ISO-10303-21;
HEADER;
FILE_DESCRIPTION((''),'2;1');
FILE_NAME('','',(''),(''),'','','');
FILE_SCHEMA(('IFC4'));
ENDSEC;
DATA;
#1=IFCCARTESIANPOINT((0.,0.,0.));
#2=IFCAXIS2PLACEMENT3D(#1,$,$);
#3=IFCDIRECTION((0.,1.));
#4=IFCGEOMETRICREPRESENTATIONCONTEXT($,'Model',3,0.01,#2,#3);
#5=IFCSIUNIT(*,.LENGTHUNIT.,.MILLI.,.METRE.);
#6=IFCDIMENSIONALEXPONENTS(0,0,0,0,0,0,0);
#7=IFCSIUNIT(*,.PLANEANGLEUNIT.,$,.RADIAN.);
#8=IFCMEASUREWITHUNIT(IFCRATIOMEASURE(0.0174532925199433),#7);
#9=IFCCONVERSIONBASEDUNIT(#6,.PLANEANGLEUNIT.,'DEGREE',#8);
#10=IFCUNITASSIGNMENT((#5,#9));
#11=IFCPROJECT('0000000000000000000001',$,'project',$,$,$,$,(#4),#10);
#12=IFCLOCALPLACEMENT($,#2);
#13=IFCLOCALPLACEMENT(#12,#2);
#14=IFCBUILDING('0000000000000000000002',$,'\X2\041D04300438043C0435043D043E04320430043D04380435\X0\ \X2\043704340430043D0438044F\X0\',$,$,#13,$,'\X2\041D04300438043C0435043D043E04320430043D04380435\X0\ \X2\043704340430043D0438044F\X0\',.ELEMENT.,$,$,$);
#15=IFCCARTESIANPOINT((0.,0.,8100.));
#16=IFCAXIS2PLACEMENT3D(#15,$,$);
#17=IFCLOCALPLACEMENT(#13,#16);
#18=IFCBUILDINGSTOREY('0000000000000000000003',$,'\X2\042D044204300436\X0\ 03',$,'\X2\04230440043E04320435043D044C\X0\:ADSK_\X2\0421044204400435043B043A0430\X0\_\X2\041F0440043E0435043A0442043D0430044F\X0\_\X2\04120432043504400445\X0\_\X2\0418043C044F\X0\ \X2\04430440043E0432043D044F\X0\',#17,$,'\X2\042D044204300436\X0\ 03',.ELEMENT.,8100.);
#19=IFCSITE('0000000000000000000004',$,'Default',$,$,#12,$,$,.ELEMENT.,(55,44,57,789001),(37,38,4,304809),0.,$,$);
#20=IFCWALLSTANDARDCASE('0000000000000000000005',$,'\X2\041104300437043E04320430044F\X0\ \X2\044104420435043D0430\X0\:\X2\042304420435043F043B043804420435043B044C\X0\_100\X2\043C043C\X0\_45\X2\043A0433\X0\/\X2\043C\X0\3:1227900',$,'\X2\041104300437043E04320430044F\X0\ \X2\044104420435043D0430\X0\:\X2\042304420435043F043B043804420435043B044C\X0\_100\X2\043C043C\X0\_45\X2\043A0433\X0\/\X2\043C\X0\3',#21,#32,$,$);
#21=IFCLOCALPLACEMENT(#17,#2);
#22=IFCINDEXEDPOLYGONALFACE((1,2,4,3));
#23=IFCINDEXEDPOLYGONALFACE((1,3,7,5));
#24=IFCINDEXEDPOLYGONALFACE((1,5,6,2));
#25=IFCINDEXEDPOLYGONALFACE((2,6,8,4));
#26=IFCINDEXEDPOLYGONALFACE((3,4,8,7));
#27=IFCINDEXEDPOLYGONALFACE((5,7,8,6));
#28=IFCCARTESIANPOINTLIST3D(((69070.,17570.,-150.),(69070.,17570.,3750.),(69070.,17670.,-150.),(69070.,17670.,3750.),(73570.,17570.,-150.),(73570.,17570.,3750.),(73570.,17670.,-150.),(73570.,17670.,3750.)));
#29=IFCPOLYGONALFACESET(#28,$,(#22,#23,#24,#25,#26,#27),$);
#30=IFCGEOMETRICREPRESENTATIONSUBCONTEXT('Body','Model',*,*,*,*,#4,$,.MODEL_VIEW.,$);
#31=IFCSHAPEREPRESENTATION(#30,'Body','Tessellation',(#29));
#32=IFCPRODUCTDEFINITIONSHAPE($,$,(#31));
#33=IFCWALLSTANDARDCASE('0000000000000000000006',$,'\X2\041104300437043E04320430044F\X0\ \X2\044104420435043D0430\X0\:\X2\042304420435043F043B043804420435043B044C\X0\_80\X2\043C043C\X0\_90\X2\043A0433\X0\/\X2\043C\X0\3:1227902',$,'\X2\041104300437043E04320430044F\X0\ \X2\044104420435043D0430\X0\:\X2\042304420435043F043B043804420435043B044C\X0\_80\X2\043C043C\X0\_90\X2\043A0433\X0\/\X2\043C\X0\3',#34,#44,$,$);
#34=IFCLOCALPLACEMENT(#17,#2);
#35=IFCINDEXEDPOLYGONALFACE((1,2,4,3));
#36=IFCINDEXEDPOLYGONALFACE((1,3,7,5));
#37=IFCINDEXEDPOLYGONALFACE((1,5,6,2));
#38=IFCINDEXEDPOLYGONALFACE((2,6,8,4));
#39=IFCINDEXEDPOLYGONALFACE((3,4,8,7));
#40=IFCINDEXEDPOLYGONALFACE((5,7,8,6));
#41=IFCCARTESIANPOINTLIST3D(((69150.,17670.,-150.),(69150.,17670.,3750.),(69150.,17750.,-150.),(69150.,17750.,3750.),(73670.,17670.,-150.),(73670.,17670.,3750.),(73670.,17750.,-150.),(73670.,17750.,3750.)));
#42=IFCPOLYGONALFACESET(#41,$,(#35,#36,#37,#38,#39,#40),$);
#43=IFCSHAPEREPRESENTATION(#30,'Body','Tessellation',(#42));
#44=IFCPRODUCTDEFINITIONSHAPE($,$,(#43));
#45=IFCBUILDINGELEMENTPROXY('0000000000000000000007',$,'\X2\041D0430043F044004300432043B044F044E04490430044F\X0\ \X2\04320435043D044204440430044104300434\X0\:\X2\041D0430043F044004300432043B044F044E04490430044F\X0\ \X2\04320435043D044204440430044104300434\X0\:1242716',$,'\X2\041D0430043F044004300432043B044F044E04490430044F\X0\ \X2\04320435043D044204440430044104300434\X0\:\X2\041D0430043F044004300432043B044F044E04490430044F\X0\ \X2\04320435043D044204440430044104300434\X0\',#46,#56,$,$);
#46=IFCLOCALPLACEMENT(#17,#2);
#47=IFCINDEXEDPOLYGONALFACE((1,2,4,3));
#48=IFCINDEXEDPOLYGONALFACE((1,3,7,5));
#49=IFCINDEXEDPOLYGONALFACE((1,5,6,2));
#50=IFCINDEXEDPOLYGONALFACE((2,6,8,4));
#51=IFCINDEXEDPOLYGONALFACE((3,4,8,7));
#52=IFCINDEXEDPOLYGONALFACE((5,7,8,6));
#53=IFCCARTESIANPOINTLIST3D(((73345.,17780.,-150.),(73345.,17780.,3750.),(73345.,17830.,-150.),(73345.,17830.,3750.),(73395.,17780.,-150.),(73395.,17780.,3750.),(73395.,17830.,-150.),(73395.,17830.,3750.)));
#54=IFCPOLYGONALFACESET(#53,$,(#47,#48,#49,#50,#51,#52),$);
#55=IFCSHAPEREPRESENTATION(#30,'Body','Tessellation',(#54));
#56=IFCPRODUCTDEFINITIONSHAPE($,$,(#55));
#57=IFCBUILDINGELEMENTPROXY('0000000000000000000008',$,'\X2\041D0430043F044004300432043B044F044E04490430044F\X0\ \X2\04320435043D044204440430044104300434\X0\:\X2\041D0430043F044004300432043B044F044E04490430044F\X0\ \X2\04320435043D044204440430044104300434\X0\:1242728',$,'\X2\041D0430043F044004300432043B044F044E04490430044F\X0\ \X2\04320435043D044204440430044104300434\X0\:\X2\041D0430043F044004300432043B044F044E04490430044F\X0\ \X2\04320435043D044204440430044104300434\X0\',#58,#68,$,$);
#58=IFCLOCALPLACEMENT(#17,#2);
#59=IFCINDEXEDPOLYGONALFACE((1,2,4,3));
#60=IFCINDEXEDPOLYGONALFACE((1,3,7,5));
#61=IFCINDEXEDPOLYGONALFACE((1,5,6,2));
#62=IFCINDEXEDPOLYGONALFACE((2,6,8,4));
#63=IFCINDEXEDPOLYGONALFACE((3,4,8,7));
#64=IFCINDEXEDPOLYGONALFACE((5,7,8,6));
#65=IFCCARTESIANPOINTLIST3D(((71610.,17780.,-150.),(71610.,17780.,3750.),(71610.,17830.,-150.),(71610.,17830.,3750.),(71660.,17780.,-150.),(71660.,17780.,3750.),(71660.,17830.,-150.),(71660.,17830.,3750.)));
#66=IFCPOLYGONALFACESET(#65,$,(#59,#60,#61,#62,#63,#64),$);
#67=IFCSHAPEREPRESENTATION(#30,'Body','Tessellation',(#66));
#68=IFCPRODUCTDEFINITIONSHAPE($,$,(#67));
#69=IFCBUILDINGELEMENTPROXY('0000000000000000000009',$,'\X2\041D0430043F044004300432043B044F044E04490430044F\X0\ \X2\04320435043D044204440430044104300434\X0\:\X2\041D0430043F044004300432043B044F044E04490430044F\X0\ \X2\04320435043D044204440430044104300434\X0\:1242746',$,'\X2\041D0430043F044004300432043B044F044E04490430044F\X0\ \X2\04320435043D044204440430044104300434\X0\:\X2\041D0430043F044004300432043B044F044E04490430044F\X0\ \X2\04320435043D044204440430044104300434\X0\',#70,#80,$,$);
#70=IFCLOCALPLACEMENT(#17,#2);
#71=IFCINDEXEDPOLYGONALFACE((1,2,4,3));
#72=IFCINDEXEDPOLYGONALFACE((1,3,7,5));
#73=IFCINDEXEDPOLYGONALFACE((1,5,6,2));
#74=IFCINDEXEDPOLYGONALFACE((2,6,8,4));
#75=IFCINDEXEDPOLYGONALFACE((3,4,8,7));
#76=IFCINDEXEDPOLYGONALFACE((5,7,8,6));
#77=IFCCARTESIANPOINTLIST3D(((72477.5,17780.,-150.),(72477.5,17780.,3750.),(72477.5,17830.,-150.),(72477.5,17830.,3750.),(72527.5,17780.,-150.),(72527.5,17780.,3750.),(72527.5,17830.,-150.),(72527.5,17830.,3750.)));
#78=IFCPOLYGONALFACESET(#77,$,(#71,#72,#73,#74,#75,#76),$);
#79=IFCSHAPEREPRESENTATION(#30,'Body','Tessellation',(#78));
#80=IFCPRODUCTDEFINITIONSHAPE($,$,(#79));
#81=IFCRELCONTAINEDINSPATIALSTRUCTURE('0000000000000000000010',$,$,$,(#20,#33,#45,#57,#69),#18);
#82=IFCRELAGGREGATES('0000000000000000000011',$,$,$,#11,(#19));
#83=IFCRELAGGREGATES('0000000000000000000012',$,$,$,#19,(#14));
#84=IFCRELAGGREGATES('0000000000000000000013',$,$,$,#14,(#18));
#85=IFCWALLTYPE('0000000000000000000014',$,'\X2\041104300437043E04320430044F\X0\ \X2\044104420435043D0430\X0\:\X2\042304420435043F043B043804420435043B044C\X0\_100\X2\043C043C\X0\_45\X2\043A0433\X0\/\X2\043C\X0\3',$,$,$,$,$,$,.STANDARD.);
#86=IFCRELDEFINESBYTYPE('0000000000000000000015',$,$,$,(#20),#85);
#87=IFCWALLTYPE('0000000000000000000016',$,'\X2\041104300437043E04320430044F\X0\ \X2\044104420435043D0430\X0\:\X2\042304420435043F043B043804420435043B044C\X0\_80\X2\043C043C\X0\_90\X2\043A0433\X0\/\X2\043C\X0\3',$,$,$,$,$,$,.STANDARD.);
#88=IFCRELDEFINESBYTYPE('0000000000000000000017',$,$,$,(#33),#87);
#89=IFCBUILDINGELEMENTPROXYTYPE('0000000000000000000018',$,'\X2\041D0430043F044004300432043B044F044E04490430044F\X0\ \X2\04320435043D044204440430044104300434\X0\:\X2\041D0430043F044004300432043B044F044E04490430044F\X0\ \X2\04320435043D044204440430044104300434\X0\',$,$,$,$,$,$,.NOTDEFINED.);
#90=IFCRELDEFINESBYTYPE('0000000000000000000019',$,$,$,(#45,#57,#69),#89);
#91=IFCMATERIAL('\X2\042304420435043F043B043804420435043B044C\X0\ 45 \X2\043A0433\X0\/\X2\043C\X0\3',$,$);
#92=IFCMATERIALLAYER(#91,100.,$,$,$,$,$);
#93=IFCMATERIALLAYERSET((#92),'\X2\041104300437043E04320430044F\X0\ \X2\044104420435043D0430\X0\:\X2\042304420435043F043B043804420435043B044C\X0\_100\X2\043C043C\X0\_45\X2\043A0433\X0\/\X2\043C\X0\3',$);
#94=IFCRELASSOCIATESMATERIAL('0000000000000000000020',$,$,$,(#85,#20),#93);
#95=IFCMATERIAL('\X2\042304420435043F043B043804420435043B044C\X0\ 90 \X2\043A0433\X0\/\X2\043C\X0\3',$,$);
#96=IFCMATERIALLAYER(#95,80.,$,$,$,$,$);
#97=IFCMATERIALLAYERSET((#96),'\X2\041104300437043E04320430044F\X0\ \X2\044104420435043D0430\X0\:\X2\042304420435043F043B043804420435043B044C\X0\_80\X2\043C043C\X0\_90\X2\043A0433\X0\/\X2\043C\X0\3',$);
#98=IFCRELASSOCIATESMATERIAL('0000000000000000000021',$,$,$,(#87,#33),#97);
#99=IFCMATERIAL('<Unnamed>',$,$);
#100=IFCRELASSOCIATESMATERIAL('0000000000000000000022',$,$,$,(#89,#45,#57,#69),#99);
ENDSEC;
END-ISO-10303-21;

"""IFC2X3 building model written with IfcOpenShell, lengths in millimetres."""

from ifc_helpers import new_model, entity, si_unit, converted_unit, direction, frame, frame_2d, origin, origin_2d_with_axis, place, context, subcontext, project, spatial, rectangle, extrude, source, transform, mapped, material, layer, layer_set, layer_usage, type_object, type_shapes, element, save


model = new_model("IFC2X3")

# Units and contexts
model_context = context("Model", 3, precision=0.01, world=origin(), true_north=direction((0.0, 1.0)))
body_context = subcontext(model_context, "Body", "Model", "MODEL_VIEW")
ifc_project = project(units=[si_unit("LENGTHUNIT", "METRE", prefix="MILLI"), converted_unit("PLANEANGLEUNIT", "DEGREE", entity("IfcRatioMeasure", 0.0174532925199433), si_unit("PLANEANGLEUNIT", "RADIAN"), dimensions=[0, 0, 0, 0, 0, 0, 0])], contexts=[model_context])

# Site, building, storey
site_placement = place(None, origin())
site = spatial("IfcSite", under=ifc_project, at=site_placement, Name="Default", CompositionType="ELEMENT", RefLatitude=(55, 44, 57, 789001), RefLongitude=(37, 38, 4, 304809), RefElevation=0.0)
building_placement = place(site_placement, origin())
building = spatial("IfcBuilding", under=site, at=building_placement, Name="Наименование здания", LongName="Наименование здания", CompositionType="ELEMENT")
storey_placement = place(building_placement, frame((0.0, 0.0, 8100.0)))
storey = spatial("IfcBuildingStorey", under=building, at=storey_placement, Name="Этаж 03", ObjectType="Уровень:ADSK_Стрелка_Проектная_Вверх_Имя уровня", LongName="Этаж 03", CompositionType="ELEMENT", Elevation=8100.0)

# Walls
ifc_material_1 = material(Name="Утеплитель 45 кг/м3")
ifc_layer_1 = layer(ifc_material_1, 100.0)
ifc_layer_set_1 = layer_set([ifc_layer_1], Name="Базовая стена:Утеплитель_100мм_45кг/м3")
ifc_layer_usage_1 = layer_usage(ifc_layer_set_1, "AXIS2", "POSITIVE", -50.0)
wall_type_1 = type_object("IfcWallType", Name="Базовая стена:Утеплитель_100мм_45кг/м3", PredefinedType="STANDARD", material=ifc_layer_set_1)
wall_1_placement = place(storey_placement, frame((73570.0, 17620.0, -150.0), z_axis=(0.0, 0.0, 1.0), x_axis=(-1.0, 0.0, 0.0)))
element("IfcWallStandardCase", 1, at=wall_1_placement, inside=storey, type_object=wall_type_1, material=ifc_layer_usage_1, Name="Базовая стена:Утеплитель_100мм_45кг/м3:1227900", ObjectType="Базовая стена:Утеплитель_100мм_45кг/м3", context=body_context, shape_type="SweptSolid", body=[
    extrude(rectangle(XDim=4500.0, YDim=100.0, at=frame_2d((2250.0, 0.0), x_axis=(-1.0, 0.0))), origin(), (0.0, 0.0, 1.0), 3900.0),
])
ifc_material_2 = material(Name="Утеплитель 90 кг/м3")
ifc_layer_2 = layer(ifc_material_2, 80.0)
ifc_layer_set_2 = layer_set([ifc_layer_2], Name="Базовая стена:Утеплитель_80мм_90кг/м3")
ifc_layer_usage_2 = layer_usage(ifc_layer_set_2, "AXIS2", "POSITIVE", -40.0)
wall_type_2 = type_object("IfcWallType", Name="Базовая стена:Утеплитель_80мм_90кг/м3", PredefinedType="STANDARD", material=ifc_layer_set_2)
wall_2_placement = place(storey_placement, frame((73670.0, 17710.0, -150.0), z_axis=(0.0, 0.0, 1.0), x_axis=(-1.0, 0.0, 0.0)))
element("IfcWallStandardCase", 2, at=wall_2_placement, inside=storey, type_object=wall_type_2, material=ifc_layer_usage_2, Name="Базовая стена:Утеплитель_80мм_90кг/м3:1227902", ObjectType="Базовая стена:Утеплитель_80мм_90кг/м3", context=body_context, shape_type="SweptSolid", body=[
    extrude(rectangle(XDim=4520.0, YDim=80.0, at=frame_2d((2260.0, 0.0), x_axis=(-1.0, 0.0))), origin(), (0.0, 0.0, 1.0), 3900.0),
])

# Building element proxies
ifc_material_3 = material(Name="<Unnamed>")
building_element_proxy_type_1 = type_object("IfcBuildingElementProxyType", Name="Направляющая вентфасад:Направляющая вентфасад", PredefinedType="NOTDEFINED", material=ifc_material_3)
shared_shape_1 = source(origin(), body_context, "Body", "SweptSolid", [
    extrude(rectangle(XDim=50.0, YDim=50.0, at=origin_2d_with_axis()), frame((25.0, -25.0, 0.0), z_axis=(0.0, 0.0, 1.0), x_axis=(-1.0, 0.0, 0.0)), (0.0, 0.0, 1.0), 3900.0),
])
type_shapes(building_element_proxy_type_1, [shared_shape_1])
for number, where, z_axis, x_axis, name in (
    (3, (73395.0, 17780.0, -150.0), (0.0, 0.0, 1.0), (-1.0, 0.0, 0.0), "Направляющая вентфасад:Направляющая вентфасад:1242716"),
    (4, (71660.0, 17780.0, -150.0), (0.0, 0.0, 1.0), (-1.0, 0.0, 0.0), "Направляющая вентфасад:Направляющая вентфасад:1242728"),
    (5, (72527.5, 17780.0, -150.0), (0.0, 0.0, 1.0), (-1.0, 0.0, 0.0), "Направляющая вентфасад:Направляющая вентфасад:1242746"),
):
    element("IfcBuildingElementProxy", number, at=place(storey_placement, frame(where, z_axis=z_axis, x_axis=x_axis)), inside=storey, type_object=building_element_proxy_type_1, material=ifc_material_3, Name=name, ObjectType="Направляющая вентфасад:Направляющая вентфасад", context=body_context, shape_type="MappedRepresentation", body=[
        mapped(shared_shape_1, transform((0.0, 0.0, 0.0), scale=1.0)),
    ])

save(model, "model.ifc")
